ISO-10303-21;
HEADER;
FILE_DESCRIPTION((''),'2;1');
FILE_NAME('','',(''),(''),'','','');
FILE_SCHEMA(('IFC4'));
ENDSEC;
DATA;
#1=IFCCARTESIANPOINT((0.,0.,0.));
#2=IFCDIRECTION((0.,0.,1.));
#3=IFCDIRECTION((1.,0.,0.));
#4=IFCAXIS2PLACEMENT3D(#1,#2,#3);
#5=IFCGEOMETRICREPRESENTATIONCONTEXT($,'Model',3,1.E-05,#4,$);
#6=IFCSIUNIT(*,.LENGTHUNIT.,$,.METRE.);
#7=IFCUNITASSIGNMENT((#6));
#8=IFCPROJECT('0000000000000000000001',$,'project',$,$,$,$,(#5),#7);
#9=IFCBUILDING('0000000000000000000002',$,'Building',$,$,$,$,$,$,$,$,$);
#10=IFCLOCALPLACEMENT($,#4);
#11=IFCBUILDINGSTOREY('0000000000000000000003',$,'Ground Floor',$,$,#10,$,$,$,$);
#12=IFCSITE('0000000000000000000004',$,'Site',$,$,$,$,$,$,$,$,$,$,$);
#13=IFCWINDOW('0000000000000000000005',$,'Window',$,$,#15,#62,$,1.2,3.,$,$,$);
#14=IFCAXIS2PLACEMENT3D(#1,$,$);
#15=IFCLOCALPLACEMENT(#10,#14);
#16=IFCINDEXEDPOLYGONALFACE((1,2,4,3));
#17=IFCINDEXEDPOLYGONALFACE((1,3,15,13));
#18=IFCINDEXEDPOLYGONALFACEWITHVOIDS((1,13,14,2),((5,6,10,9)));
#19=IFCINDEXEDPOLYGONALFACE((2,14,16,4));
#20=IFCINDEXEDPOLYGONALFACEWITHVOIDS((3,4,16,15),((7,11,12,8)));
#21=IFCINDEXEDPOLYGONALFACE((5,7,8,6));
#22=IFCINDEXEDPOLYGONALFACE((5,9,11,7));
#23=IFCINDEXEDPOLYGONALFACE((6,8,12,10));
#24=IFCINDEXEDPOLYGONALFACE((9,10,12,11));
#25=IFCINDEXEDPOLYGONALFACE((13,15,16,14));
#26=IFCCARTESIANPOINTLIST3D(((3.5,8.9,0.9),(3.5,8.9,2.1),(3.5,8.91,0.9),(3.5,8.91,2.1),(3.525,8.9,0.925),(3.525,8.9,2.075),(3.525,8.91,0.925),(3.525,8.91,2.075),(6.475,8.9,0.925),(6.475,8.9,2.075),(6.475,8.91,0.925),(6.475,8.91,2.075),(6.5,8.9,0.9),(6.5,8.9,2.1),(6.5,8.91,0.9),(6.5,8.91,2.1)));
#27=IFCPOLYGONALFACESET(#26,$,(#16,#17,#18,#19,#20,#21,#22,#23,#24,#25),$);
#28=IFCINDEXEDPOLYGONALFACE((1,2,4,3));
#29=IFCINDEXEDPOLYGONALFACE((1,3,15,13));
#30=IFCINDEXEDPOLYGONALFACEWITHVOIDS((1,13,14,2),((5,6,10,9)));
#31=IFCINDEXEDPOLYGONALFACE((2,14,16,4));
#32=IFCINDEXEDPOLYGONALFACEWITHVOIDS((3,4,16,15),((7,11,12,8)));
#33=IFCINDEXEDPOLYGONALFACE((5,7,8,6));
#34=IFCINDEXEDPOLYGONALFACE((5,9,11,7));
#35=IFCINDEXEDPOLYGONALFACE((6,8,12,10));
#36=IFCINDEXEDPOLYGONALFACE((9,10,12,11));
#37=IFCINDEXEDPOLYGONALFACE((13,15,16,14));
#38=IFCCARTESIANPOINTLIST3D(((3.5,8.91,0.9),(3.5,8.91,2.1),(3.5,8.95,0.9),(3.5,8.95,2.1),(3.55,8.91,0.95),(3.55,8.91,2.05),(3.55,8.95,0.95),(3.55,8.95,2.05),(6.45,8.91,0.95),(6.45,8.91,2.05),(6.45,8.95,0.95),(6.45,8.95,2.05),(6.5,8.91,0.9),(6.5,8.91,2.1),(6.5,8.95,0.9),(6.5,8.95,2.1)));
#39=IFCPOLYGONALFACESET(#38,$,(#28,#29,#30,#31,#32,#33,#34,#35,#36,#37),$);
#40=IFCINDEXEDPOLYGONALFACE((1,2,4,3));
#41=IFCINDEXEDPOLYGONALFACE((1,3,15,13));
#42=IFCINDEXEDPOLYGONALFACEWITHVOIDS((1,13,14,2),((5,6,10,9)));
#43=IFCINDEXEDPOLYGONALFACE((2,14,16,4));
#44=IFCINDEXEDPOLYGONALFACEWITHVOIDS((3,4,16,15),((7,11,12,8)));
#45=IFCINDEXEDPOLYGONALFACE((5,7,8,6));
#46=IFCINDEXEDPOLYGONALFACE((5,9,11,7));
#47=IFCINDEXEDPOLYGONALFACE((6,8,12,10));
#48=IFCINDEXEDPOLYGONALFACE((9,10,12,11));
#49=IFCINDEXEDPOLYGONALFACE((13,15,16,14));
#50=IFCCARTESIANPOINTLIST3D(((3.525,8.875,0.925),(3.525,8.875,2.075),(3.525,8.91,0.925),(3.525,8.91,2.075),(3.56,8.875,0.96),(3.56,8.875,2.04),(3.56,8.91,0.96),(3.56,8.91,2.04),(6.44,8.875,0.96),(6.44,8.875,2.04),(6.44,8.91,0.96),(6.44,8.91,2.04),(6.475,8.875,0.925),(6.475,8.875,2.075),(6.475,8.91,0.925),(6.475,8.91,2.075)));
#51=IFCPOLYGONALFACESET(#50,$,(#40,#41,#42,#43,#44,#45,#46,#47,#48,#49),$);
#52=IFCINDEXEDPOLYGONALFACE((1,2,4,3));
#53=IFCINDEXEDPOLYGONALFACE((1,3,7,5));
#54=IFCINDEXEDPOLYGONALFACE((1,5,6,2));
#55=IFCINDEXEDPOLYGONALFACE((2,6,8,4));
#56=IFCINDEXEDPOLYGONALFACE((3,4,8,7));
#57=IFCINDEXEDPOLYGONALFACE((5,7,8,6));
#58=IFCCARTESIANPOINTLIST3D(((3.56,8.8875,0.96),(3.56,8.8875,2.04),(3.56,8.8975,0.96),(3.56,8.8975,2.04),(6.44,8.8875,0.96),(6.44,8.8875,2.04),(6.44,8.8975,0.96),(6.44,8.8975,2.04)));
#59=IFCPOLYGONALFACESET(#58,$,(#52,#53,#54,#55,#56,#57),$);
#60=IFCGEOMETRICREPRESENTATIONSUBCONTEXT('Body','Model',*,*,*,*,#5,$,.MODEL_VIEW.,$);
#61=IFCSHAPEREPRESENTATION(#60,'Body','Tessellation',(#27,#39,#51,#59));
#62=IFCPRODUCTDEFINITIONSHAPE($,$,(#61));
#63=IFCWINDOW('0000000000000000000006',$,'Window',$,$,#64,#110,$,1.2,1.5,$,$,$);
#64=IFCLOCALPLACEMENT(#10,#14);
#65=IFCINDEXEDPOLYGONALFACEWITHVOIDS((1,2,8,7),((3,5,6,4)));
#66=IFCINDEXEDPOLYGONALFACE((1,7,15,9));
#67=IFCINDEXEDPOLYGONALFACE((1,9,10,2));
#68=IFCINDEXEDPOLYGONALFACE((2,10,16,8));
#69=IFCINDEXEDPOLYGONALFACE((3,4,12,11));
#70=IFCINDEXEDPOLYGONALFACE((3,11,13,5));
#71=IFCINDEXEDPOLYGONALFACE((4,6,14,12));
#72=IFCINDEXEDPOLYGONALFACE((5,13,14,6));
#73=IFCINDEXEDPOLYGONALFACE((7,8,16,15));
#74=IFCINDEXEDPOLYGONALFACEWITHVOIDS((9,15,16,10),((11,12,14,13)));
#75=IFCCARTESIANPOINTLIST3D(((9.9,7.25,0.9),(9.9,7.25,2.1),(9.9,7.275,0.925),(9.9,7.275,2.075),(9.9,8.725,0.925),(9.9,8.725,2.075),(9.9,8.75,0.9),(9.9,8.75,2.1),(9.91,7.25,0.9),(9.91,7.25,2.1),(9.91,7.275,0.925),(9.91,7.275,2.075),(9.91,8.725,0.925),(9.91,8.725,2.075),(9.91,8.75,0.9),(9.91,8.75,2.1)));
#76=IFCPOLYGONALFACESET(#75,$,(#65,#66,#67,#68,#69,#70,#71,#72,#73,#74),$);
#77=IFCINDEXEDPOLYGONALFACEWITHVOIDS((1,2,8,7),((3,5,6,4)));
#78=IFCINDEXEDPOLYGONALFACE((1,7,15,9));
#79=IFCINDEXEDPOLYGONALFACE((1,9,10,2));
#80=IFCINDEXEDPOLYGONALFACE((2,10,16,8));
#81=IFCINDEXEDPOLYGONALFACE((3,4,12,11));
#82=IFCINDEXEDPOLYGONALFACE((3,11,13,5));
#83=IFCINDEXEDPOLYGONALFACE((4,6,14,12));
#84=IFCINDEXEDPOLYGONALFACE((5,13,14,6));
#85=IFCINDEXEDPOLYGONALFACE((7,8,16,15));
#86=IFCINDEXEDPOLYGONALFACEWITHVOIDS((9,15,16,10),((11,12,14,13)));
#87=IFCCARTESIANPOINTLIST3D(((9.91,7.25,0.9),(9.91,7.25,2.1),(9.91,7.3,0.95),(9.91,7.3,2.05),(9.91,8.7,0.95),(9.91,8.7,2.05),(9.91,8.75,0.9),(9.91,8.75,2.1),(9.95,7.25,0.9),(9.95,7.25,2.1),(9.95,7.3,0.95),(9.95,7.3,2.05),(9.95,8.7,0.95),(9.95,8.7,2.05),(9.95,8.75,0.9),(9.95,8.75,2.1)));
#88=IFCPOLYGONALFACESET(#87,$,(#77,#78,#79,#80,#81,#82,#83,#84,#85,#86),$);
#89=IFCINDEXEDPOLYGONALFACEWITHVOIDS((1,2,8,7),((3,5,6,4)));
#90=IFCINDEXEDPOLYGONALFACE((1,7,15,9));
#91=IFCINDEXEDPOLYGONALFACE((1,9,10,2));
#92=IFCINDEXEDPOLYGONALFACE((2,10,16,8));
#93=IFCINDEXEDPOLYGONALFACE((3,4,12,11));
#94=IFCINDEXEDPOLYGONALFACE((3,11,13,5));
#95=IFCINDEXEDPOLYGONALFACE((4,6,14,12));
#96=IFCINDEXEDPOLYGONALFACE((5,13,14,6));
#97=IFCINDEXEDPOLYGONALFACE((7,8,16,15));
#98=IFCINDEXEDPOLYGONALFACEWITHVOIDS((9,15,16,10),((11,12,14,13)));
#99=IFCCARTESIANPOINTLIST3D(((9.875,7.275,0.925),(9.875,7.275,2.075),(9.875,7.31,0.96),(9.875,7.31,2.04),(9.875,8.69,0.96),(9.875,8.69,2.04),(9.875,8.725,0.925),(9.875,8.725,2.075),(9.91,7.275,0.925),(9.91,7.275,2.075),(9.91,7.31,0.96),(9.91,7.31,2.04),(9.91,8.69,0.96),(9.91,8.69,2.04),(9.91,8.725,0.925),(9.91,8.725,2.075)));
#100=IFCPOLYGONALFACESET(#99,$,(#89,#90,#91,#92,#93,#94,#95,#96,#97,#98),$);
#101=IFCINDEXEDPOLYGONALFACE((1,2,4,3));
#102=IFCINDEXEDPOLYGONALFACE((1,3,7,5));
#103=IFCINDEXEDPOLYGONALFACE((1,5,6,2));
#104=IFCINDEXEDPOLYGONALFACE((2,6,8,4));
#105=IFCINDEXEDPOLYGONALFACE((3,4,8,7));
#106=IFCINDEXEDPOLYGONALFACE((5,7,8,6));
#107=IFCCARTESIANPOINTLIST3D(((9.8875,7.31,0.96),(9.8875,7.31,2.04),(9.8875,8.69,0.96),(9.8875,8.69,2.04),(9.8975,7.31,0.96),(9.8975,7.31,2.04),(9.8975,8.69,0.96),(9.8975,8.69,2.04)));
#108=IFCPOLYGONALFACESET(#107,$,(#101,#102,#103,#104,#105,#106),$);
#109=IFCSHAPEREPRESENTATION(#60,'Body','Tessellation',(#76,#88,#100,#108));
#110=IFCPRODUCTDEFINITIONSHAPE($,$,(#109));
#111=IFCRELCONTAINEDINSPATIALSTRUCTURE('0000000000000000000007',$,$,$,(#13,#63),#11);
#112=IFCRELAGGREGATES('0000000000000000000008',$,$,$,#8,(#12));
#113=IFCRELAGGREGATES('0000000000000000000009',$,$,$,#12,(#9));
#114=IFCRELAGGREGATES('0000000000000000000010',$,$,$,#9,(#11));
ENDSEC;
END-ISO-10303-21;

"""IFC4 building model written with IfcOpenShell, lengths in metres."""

from ifc_helpers import new_model, si_unit, frame, origin_with_axes, place, context, subcontext, project, spatial, line, indexed_curve, outline, extrude, element, save


model = new_model("IFC4")

# Units and contexts
model_context = context("Model", 3, precision=1e-05, world=origin_with_axes())
body_context = subcontext(model_context, "Body", "Model", "MODEL_VIEW")
ifc_project = project(units=[si_unit("LENGTHUNIT", "METRE")], contexts=[model_context])

# Site, building, storey
site = spatial("IfcSite", under=ifc_project, Name="Site")
building = spatial("IfcBuilding", under=site, Name="Building")
storey_placement = place(None, origin_with_axes())
storey = spatial("IfcBuildingStorey", under=building, at=storey_placement, Name="Ground Floor")

# Windows
window_1_placement = place(storey_placement, frame((6.5, 9.0, 0.9), z_axis=(0.0, 0.0, 1.0), x_axis=(-1.0, 0.0, 0.0)))
element("IfcWindow", 1, at=window_1_placement, inside=storey, Name="Window", OverallHeight=1.2, OverallWidth=3.0, context=body_context, shape_type="SweptSolid", body=[
    extrude(outline(indexed_curve([(0.0, 0.0), (3.0, 0.0), (3.0, 1.2), (0.0, 1.2)], segments=[line(1, 2, 3, 4, 1)]), holes=[indexed_curve([(0.025, 0.025), (2.975, 0.025), (2.975, 1.175), (0.025, 1.175)], segments=[line(1, 2, 3, 4, 1)])]), frame((0.0, 0.09, 0.0), z_axis=(0.0, -1.0, 0.0), x_axis=(1.0, 0.0, 0.0)), (0.0, 0.0, -1.0), 0.01),
    extrude(outline(indexed_curve([(0.0, 0.0), (3.0, 0.0), (3.0, 1.2), (0.0, 1.2)], segments=[line(1, 2, 3, 4, 1)]), holes=[indexed_curve([(0.05, 0.05), (2.95, 0.05), (2.95, 1.15), (0.05, 1.15)], segments=[line(1, 2, 3, 4, 1)])]), frame((0.0, 0.05, 0.0), z_axis=(0.0, -1.0, 0.0), x_axis=(1.0, 0.0, 0.0)), (0.0, 0.0, -1.0), 0.04),
    extrude(outline(indexed_curve([(0.0, 0.0), (2.95, 0.0), (2.95, 1.15), (0.0, 1.15)], segments=[line(1, 2, 3, 4, 1)]), holes=[indexed_curve([(0.035, 0.035), (2.915, 0.035), (2.915, 1.115), (0.035, 1.115)], segments=[line(1, 2, 3, 4, 1)])]), frame((0.025, 0.09, 0.025), z_axis=(0.0, -1.0, 0.0), x_axis=(1.0, 0.0, 0.0)), (0.0, 0.0, -1.0), 0.035),
    extrude(outline(indexed_curve([(0.035, 0.035), (2.915, 0.035), (2.915, 1.115), (0.035, 1.115)], segments=[line(1, 2, 3, 4, 1)])), frame((0.025, 0.1025, 0.025), z_axis=(0.0, -1.0, 0.0), x_axis=(1.0, 0.0, 0.0)), (0.0, 0.0, -1.0), 0.01),
])
window_2_placement = place(storey_placement, frame((10.0, 7.25, 0.9), z_axis=(0.0, 0.0, 1.0), x_axis=(0.0, 1.0, 0.0)))
element("IfcWindow", 2, at=window_2_placement, inside=storey, Name="Window", OverallHeight=1.2, OverallWidth=1.5, context=body_context, shape_type="SweptSolid", body=[
    extrude(outline(indexed_curve([(0.0, 0.0), (1.5, 0.0), (1.5, 1.2), (0.0, 1.2)], segments=[line(1, 2, 3, 4, 1)]), holes=[indexed_curve([(0.025, 0.025), (1.475, 0.025), (1.475, 1.175), (0.025, 1.175)], segments=[line(1, 2, 3, 4, 1)])]), frame((0.0, 0.09, 0.0), z_axis=(0.0, -1.0, 0.0), x_axis=(1.0, 0.0, 0.0)), (0.0, 0.0, -1.0), 0.01),
    extrude(outline(indexed_curve([(0.0, 0.0), (1.5, 0.0), (1.5, 1.2), (0.0, 1.2)], segments=[line(1, 2, 3, 4, 1)]), holes=[indexed_curve([(0.05, 0.05), (1.45, 0.05), (1.45, 1.15), (0.05, 1.15)], segments=[line(1, 2, 3, 4, 1)])]), frame((0.0, 0.05, 0.0), z_axis=(0.0, -1.0, 0.0), x_axis=(1.0, 0.0, 0.0)), (0.0, 0.0, -1.0), 0.04),
    extrude(outline(indexed_curve([(0.0, 0.0), (1.45, 0.0), (1.45, 1.15), (0.0, 1.15)], segments=[line(1, 2, 3, 4, 1)]), holes=[indexed_curve([(0.035, 0.035), (1.415, 0.035), (1.415, 1.115), (0.035, 1.115)], segments=[line(1, 2, 3, 4, 1)])]), frame((0.025, 0.09, 0.025), z_axis=(0.0, -1.0, 0.0), x_axis=(1.0, 0.0, 0.0)), (0.0, 0.0, -1.0), 0.035),
    extrude(outline(indexed_curve([(0.035, 0.035), (1.415, 0.035), (1.415, 1.115), (0.035, 1.115)], segments=[line(1, 2, 3, 4, 1)])), frame((0.025, 0.1025, 0.025), z_axis=(0.0, -1.0, 0.0), x_axis=(1.0, 0.0, 0.0)), (0.0, 0.0, -1.0), 0.01),
])

save(model, "model.ifc")
